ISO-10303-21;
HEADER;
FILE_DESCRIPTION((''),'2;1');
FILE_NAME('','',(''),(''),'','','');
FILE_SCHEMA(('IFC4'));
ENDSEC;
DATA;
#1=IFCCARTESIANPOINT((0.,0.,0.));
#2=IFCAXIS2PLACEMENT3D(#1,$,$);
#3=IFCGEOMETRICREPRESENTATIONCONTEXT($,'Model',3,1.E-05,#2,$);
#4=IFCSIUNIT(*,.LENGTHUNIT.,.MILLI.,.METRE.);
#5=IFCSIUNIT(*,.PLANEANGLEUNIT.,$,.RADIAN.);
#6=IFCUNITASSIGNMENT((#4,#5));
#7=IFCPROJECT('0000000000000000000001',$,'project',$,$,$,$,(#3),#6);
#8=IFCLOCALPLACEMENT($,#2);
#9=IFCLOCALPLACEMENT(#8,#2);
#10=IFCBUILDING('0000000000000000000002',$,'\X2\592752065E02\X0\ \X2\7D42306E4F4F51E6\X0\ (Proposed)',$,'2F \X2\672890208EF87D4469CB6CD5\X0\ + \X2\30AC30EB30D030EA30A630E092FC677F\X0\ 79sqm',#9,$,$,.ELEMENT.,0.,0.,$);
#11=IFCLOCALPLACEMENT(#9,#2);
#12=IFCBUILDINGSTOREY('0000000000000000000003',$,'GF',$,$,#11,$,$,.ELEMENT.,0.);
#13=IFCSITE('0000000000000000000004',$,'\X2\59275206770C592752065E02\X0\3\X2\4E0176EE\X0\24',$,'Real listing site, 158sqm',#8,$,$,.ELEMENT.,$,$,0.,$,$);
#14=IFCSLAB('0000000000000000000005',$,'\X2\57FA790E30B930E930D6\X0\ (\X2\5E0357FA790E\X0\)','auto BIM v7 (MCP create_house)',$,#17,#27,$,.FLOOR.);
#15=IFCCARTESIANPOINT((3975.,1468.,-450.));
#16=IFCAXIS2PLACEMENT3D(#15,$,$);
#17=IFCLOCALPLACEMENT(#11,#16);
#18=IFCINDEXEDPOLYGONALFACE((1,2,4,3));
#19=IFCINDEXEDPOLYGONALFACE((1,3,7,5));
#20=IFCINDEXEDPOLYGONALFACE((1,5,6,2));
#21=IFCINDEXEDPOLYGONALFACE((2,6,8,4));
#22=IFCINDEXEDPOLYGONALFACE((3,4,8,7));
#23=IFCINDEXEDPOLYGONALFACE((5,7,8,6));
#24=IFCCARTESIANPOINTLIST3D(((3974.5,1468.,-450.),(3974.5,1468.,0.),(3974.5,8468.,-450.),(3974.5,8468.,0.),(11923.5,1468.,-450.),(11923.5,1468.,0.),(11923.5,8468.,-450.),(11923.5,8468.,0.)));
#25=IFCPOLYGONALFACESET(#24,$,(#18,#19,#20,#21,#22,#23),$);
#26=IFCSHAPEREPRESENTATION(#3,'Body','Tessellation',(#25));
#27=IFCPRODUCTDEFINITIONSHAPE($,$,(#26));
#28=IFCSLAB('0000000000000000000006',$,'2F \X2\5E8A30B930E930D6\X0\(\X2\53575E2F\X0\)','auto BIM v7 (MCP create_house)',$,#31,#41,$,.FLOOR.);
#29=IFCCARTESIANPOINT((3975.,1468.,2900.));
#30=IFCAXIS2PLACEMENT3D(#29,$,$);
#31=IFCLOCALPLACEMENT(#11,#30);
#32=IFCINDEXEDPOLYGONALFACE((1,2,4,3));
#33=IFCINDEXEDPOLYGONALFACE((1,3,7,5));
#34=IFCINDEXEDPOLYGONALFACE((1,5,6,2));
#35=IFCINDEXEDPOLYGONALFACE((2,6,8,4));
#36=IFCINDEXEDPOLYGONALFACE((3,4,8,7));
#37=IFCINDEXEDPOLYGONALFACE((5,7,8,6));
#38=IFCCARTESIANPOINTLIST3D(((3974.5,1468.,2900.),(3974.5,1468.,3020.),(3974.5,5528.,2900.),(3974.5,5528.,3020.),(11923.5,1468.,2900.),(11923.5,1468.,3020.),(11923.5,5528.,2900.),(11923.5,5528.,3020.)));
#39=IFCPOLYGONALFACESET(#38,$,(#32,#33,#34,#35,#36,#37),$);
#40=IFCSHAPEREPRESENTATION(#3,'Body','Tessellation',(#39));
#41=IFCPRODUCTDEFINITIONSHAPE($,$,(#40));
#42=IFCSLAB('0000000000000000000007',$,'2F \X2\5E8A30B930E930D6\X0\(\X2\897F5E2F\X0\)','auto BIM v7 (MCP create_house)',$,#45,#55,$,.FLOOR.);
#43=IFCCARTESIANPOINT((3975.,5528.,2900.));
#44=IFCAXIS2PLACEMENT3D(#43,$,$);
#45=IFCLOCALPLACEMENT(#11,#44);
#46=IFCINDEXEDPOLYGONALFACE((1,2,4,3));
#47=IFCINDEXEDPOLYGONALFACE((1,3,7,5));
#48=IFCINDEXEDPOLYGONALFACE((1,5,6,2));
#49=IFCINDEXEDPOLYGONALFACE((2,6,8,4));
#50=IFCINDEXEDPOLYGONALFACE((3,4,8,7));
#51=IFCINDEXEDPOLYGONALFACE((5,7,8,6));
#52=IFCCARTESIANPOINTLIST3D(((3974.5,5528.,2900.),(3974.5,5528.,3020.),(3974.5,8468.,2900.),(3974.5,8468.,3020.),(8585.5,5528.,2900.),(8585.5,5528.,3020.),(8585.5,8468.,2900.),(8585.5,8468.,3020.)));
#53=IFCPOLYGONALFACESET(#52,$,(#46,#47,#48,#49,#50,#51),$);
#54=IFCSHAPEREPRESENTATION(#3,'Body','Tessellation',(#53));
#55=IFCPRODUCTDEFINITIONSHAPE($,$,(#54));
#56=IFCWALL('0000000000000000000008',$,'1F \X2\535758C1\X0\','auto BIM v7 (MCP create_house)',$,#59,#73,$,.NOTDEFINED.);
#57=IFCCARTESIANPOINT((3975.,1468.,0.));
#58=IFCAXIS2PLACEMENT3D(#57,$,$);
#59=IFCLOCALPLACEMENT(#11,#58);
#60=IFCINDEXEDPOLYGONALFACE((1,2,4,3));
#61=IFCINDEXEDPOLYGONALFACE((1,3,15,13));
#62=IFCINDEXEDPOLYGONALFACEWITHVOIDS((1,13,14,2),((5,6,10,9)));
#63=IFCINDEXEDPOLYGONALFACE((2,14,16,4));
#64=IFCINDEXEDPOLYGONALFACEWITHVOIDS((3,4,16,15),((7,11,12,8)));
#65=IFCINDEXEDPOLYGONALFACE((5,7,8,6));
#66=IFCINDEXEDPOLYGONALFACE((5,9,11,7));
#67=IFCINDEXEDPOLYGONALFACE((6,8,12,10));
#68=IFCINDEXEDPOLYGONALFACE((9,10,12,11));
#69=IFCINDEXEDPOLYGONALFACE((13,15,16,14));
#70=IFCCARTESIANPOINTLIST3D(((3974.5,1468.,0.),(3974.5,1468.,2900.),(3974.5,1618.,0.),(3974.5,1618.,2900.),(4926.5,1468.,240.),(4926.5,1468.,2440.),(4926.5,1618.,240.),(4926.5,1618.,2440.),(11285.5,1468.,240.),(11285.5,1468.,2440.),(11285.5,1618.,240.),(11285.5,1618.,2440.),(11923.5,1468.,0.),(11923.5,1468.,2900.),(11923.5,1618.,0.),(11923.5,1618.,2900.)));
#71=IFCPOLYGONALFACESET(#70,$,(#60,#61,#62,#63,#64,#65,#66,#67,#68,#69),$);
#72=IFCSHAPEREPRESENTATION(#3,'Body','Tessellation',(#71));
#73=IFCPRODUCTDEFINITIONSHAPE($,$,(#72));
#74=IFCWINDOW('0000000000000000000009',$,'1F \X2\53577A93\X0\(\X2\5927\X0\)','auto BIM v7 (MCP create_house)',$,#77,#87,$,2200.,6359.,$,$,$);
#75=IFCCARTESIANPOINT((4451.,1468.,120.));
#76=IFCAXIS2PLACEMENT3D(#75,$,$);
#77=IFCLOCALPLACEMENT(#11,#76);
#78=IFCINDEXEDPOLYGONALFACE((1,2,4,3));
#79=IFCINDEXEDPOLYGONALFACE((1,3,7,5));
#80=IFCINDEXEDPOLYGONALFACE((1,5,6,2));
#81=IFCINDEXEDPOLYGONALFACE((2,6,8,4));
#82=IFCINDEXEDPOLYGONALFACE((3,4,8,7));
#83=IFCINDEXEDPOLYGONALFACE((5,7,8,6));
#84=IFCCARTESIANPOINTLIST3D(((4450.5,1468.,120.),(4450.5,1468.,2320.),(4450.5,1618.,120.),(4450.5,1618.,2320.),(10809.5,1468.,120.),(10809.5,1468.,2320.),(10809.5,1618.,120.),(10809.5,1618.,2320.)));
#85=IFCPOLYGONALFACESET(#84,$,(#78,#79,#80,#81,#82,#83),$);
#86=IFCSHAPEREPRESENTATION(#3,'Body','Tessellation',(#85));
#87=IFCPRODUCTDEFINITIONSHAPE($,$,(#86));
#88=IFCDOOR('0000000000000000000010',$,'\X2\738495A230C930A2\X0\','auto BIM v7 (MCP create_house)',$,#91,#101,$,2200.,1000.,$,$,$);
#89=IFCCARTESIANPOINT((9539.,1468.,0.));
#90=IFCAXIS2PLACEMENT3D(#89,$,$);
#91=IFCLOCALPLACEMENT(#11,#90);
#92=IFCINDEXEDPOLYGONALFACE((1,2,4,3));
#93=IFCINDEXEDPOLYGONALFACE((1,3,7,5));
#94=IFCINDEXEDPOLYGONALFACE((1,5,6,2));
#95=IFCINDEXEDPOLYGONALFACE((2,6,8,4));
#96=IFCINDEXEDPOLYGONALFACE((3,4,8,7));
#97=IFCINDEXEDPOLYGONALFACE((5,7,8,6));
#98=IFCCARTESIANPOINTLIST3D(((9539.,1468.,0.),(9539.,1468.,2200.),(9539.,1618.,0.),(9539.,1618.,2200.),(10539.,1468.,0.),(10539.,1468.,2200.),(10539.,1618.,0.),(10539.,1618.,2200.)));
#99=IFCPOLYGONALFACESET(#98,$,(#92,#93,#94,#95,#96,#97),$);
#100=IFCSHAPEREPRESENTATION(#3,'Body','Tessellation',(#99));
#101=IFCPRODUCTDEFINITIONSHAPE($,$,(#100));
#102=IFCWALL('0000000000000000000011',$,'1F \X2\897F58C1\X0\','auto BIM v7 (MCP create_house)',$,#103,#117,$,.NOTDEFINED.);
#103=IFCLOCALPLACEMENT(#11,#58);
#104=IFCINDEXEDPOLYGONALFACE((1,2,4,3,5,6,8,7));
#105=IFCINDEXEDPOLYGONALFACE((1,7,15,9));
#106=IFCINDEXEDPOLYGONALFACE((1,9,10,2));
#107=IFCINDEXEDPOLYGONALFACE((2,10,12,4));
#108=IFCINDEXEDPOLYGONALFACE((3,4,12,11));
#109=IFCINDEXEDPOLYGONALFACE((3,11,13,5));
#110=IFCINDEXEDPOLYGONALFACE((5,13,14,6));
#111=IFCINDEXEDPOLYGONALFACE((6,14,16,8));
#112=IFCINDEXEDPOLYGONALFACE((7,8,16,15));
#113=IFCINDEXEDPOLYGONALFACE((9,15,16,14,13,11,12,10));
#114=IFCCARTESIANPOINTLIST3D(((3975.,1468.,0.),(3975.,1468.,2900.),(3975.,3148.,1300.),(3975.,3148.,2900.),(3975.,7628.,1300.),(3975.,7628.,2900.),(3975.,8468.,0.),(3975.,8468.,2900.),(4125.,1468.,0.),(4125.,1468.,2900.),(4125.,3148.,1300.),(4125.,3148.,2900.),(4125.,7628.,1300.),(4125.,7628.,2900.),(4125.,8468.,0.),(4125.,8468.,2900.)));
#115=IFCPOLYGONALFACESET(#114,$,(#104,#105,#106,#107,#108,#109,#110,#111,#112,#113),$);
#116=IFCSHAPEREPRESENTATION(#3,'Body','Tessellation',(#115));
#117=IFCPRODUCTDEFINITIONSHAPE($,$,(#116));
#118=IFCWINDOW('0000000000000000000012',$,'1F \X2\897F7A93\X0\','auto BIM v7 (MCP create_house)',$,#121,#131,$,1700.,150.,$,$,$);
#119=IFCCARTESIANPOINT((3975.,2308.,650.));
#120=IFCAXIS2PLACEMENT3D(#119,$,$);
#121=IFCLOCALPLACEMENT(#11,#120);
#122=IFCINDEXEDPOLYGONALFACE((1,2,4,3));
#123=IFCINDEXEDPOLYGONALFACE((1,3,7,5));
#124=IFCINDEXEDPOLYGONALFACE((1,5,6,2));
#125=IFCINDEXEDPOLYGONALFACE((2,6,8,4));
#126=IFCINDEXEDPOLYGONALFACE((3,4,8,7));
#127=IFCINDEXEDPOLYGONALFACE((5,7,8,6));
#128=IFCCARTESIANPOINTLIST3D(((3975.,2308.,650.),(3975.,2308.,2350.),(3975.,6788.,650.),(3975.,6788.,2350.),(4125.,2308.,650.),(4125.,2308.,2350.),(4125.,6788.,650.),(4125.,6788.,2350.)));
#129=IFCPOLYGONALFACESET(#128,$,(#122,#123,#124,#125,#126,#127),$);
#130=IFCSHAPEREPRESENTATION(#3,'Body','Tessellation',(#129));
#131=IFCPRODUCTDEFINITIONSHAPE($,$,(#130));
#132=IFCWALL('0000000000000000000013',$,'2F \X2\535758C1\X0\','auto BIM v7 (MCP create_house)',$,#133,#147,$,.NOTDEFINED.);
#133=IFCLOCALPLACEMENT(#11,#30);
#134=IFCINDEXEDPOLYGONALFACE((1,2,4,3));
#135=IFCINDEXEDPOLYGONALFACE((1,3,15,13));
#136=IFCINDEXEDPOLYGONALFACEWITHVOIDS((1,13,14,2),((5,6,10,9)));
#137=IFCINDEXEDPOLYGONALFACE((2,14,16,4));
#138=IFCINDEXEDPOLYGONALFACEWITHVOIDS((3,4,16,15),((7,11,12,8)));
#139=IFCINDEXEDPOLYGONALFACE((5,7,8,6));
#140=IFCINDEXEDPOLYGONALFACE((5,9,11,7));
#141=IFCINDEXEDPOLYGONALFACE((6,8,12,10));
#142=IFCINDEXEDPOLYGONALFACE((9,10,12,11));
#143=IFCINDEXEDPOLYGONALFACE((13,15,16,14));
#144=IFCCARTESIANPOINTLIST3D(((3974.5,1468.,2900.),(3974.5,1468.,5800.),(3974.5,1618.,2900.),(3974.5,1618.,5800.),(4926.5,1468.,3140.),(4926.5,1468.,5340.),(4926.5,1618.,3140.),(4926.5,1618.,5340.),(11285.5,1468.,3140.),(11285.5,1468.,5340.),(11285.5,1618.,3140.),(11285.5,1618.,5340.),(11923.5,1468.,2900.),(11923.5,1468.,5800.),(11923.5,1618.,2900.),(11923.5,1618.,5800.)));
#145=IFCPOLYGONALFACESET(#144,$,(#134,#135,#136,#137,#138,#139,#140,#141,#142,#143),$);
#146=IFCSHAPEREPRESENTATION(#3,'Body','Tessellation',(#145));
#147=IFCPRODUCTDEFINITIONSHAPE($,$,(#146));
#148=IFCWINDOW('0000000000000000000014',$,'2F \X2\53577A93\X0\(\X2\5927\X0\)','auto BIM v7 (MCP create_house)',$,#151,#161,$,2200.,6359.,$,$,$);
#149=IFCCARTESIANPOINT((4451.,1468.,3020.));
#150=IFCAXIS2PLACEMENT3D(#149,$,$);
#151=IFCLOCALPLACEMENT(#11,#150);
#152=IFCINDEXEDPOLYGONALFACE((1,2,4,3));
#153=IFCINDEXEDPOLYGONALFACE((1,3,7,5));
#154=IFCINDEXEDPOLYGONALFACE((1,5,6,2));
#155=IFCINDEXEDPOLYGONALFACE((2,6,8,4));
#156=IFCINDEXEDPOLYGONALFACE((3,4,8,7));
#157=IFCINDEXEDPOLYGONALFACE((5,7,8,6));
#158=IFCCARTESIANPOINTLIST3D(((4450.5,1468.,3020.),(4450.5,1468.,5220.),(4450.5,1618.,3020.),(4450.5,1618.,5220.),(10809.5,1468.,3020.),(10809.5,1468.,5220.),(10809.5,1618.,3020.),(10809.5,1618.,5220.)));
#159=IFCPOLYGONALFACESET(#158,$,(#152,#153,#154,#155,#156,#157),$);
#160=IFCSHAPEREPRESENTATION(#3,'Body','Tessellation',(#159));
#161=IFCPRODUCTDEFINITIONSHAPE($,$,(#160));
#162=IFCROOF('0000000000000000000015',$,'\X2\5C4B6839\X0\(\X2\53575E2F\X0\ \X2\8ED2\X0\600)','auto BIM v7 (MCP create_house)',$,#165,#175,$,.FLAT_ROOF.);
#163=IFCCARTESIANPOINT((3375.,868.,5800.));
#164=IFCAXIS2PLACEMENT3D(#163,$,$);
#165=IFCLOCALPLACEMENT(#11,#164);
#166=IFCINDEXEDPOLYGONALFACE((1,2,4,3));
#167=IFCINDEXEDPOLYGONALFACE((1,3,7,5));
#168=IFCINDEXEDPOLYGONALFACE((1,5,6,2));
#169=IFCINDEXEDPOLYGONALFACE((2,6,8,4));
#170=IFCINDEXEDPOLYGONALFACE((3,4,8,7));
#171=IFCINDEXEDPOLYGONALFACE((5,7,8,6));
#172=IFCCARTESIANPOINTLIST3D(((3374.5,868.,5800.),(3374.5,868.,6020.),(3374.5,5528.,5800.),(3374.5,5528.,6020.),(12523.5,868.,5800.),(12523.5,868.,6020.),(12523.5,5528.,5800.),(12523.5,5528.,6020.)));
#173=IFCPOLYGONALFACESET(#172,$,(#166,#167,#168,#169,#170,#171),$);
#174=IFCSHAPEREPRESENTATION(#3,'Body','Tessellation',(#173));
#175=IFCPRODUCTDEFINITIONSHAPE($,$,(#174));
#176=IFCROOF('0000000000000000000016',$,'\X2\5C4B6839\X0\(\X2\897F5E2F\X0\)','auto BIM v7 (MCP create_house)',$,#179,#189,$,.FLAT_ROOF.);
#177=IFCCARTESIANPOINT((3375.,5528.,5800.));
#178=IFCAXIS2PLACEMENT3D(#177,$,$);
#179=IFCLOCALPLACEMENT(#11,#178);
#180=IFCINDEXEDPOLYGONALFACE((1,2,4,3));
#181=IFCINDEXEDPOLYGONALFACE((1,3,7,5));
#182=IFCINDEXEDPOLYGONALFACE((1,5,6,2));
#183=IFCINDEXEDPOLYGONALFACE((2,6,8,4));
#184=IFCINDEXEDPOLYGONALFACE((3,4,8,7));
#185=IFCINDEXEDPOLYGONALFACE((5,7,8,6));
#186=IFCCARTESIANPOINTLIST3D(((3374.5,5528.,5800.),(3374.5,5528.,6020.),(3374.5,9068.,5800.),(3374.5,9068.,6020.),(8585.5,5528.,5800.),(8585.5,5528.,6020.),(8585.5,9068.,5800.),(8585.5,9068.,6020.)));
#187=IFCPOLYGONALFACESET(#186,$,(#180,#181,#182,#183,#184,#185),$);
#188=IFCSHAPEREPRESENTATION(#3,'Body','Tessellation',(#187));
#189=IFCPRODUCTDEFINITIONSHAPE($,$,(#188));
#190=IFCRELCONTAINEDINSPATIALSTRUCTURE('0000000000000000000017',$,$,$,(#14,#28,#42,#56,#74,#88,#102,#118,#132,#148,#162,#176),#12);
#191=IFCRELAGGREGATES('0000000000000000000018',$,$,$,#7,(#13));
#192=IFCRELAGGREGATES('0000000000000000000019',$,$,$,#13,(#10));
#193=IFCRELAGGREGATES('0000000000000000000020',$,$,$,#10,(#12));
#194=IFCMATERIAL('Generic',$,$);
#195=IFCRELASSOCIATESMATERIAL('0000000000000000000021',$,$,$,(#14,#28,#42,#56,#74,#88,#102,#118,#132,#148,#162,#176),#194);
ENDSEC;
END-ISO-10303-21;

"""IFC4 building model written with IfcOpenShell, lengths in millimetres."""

from ifc_helpers import new_model, si_unit, frame, frame_2d, origin, place, context, project, spatial, rectangle, extrude, material, element, fill, save


model = new_model("IFC4")

# Units and contexts
model_context = context("Model", 3, precision=1e-05, world=origin())
ifc_project = project(units=[si_unit("LENGTHUNIT", "METRE", prefix="MILLI"), si_unit("PLANEANGLEUNIT", "RADIAN")], contexts=[model_context])

# Site, building, storey
site_placement = place(None, origin())
site = spatial("IfcSite", under=ifc_project, at=site_placement, Name="大分県大分市3丁目24", ObjectType="Real listing site, 158sqm", CompositionType="ELEMENT", RefElevation=0.0)
building_placement = place(site_placement, origin())
building = spatial("IfcBuilding", under=site, at=building_placement, Name="大分市 終の住処 (Proposed)", ObjectType="2F 木造軸組構法 + ガルバリウム鋼板 79sqm", CompositionType="ELEMENT", ElevationOfRefHeight=0.0, ElevationOfTerrain=0.0)
storey_placement = place(building_placement, origin())
storey = spatial("IfcBuildingStorey", under=building, at=storey_placement, Name="GF", CompositionType="ELEMENT", Elevation=0.0)

# Slabs
ifc_material = material(Name="Generic")
slab_1_placement = place(storey_placement, frame((3975.0, 1468.0, -450.0)))
element("IfcSlab", 1, at=slab_1_placement, inside=storey, material=ifc_material, Name="基礎スラブ (布基礎)", Description="auto BIM v7 (MCP create_house)", PredefinedType="FLOOR", context=model_context, shape_type="SweptSolid", body=[
    extrude(rectangle(XDim=7949.0, YDim=7000.0, at=frame_2d((3974.0, 3500.0))), frame((3975.0, 1468.0, -450.0)), (0.0, 0.0, 1.0), 450.0),
])
slab_2_placement = place(storey_placement, frame((3975.0, 1468.0, 2900.0)))
element("IfcSlab", 2, at=slab_2_placement, inside=storey, material=ifc_material, Name="2F 床スラブ(南帯)", Description="auto BIM v7 (MCP create_house)", PredefinedType="FLOOR", context=model_context, shape_type="SweptSolid", body=[
    extrude(rectangle(XDim=7949.0, YDim=4060.0, at=frame_2d((3974.0, 2030.0))), frame((3975.0, 1468.0, 2900.0)), (0.0, 0.0, 1.0), 120.0),
])
slab_3_placement = place(storey_placement, frame((3975.0, 5528.0, 2900.0)))
element("IfcSlab", 3, at=slab_3_placement, inside=storey, material=ifc_material, Name="2F 床スラブ(西帯)", Description="auto BIM v7 (MCP create_house)", PredefinedType="FLOOR", context=model_context, shape_type="SweptSolid", body=[
    extrude(rectangle(XDim=4611.0, YDim=2940.0, at=frame_2d((2305.0, 1470.0))), frame((3975.0, 5528.0, 2900.0)), (0.0, 0.0, 1.0), 120.0),
])

# Wall, openings, window, door
wall_1_placement = place(storey_placement, frame((3975.0, 1468.0, 0.0)))
wall_1 = element("IfcWall", 4, at=wall_1_placement, inside=storey, material=ifc_material, Name="1F 南壁", Description="auto BIM v7 (MCP create_house)", PredefinedType="NOTDEFINED", context=model_context, shape_type="SweptSolid", body=[
    extrude(rectangle(XDim=7949.0, YDim=150.0, at=frame_2d((3974.0, 75.0))), frame((3975.0, 1468.0, 0.0)), (0.0, 0.0, 1.0), 2900.0),
])
opening_1_placement = place(storey_placement, frame((4451.0, 1468.0, 120.0)))
opening_1 = element("IfcOpeningElement", 5, at=opening_1_placement, cuts=wall_1, PredefinedType="NOTDEFINED", context=model_context, shape_type="SweptSolid", body=[
    extrude(rectangle(XDim=6359.0, YDim=150.0, at=frame_2d((3179.0, 75.0))), frame((4451.0, 1468.0, 120.0)), (0.0, 0.0, 1.0), 2200.0),
])
opening_2_placement = place(storey_placement, frame((9539.0, 1468.0, 0.0)))
opening_2 = element("IfcOpeningElement", 6, at=opening_2_placement, cuts=wall_1, PredefinedType="NOTDEFINED", context=model_context, shape_type="SweptSolid", body=[
    extrude(rectangle(XDim=1000.0, YDim=150.0, at=frame_2d((500.0, 75.0))), frame((9539.0, 1468.0, 0.0)), (0.0, 0.0, 1.0), 2200.0),
])
window_1_placement = place(storey_placement, frame((4451.0, 1468.0, 120.0)))
window_1 = element("IfcWindow", 7, at=window_1_placement, inside=storey, material=ifc_material, Name="1F 南窓(大)", Description="auto BIM v7 (MCP create_house)", OverallHeight=2200.0, OverallWidth=6359.0, context=model_context, shape_type="SweptSolid", body=[
    extrude(rectangle(XDim=6359.0, YDim=150.0, at=frame_2d((3179.0, 75.0))), frame((4451.0, 1468.0, 120.0)), (0.0, 0.0, 1.0), 2200.0),
])
fill(opening_1, window_1)
door_placement = place(storey_placement, frame((9539.0, 1468.0, 0.0)))
door = element("IfcDoor", 8, at=door_placement, inside=storey, material=ifc_material, Name="玄関ドア", Description="auto BIM v7 (MCP create_house)", OverallHeight=2200.0, OverallWidth=1000.0, context=model_context, shape_type="SweptSolid", body=[
    extrude(rectangle(XDim=1000.0, YDim=150.0, at=frame_2d((500.0, 75.0))), frame((9539.0, 1468.0, 0.0)), (0.0, 0.0, 1.0), 2200.0),
])
fill(opening_2, door)

# Wall, opening, window
wall_2_placement = place(storey_placement, frame((3975.0, 1468.0, 0.0)))
wall_2 = element("IfcWall", 9, at=wall_2_placement, inside=storey, material=ifc_material, Name="1F 西壁", Description="auto BIM v7 (MCP create_house)", PredefinedType="NOTDEFINED", context=model_context, shape_type="SweptSolid", body=[
    extrude(rectangle(XDim=150.0, YDim=7000.0, at=frame_2d((75.0, 3500.0))), frame((3975.0, 1468.0, 0.0)), (0.0, 0.0, 1.0), 2900.0),
])
opening_3_placement = place(storey_placement, frame((3975.0, 2308.0, 650.0)))
opening_3 = element("IfcOpeningElement", 10, at=opening_3_placement, cuts=wall_2, PredefinedType="NOTDEFINED", context=model_context, shape_type="SweptSolid", body=[
    extrude(rectangle(XDim=150.0, YDim=4480.0, at=frame_2d((75.0, 2240.0))), frame((3975.0, 2308.0, 650.0)), (0.0, 0.0, 1.0), 1700.0),
])
window_2_placement = place(storey_placement, frame((3975.0, 2308.0, 650.0)))
window_2 = element("IfcWindow", 11, at=window_2_placement, inside=storey, material=ifc_material, Name="1F 西窓", Description="auto BIM v7 (MCP create_house)", OverallHeight=1700.0, OverallWidth=150.0, context=model_context, shape_type="SweptSolid", body=[
    extrude(rectangle(XDim=150.0, YDim=4480.0, at=frame_2d((75.0, 2240.0))), frame((3975.0, 2308.0, 650.0)), (0.0, 0.0, 1.0), 1700.0),
])
fill(opening_3, window_2)

# Wall, opening, window
wall_3_placement = place(storey_placement, frame((3975.0, 1468.0, 2900.0)))
wall_3 = element("IfcWall", 12, at=wall_3_placement, inside=storey, material=ifc_material, Name="2F 南壁", Description="auto BIM v7 (MCP create_house)", PredefinedType="NOTDEFINED", context=model_context, shape_type="SweptSolid", body=[
    extrude(rectangle(XDim=7949.0, YDim=150.0, at=frame_2d((3974.0, 75.0))), frame((3975.0, 1468.0, 2900.0)), (0.0, 0.0, 1.0), 2900.0),
])
opening_4_placement = place(storey_placement, frame((4451.0, 1468.0, 3020.0)))
opening_4 = element("IfcOpeningElement", 13, at=opening_4_placement, cuts=wall_3, PredefinedType="NOTDEFINED", context=model_context, shape_type="SweptSolid", body=[
    extrude(rectangle(XDim=6359.0, YDim=150.0, at=frame_2d((3179.0, 75.0))), frame((4451.0, 1468.0, 3020.0)), (0.0, 0.0, 1.0), 2200.0),
])
window_3_placement = place(storey_placement, frame((4451.0, 1468.0, 3020.0)))
window_3 = element("IfcWindow", 14, at=window_3_placement, inside=storey, material=ifc_material, Name="2F 南窓(大)", Description="auto BIM v7 (MCP create_house)", OverallHeight=2200.0, OverallWidth=6359.0, context=model_context, shape_type="SweptSolid", body=[
    extrude(rectangle(XDim=6359.0, YDim=150.0, at=frame_2d((3179.0, 75.0))), frame((4451.0, 1468.0, 3020.0)), (0.0, 0.0, 1.0), 2200.0),
])
fill(opening_4, window_3)

# Roofs
roof_1_placement = place(storey_placement, frame((3375.0, 868.0, 5800.0)))
element("IfcRoof", 15, at=roof_1_placement, inside=storey, material=ifc_material, Name="屋根(南帯 軒600)", Description="auto BIM v7 (MCP create_house)", PredefinedType="FLAT_ROOF", context=model_context, shape_type="SweptSolid", body=[
    extrude(rectangle(XDim=9149.0, YDim=4660.0, at=frame_2d((4574.0, 2330.0))), frame((3375.0, 868.0, 5800.0)), (0.0, 0.0, 1.0), 220.0),
])
roof_2_placement = place(storey_placement, frame((3375.0, 5528.0, 5800.0)))
element("IfcRoof", 16, at=roof_2_placement, inside=storey, material=ifc_material, Name="屋根(西帯)", Description="auto BIM v7 (MCP create_house)", PredefinedType="FLAT_ROOF", context=model_context, shape_type="SweptSolid", body=[
    extrude(rectangle(XDim=5211.0, YDim=3540.0, at=frame_2d((2605.0, 1770.0))), frame((3375.0, 5528.0, 5800.0)), (0.0, 0.0, 1.0), 220.0),
])

save(model, "model.ifc")
